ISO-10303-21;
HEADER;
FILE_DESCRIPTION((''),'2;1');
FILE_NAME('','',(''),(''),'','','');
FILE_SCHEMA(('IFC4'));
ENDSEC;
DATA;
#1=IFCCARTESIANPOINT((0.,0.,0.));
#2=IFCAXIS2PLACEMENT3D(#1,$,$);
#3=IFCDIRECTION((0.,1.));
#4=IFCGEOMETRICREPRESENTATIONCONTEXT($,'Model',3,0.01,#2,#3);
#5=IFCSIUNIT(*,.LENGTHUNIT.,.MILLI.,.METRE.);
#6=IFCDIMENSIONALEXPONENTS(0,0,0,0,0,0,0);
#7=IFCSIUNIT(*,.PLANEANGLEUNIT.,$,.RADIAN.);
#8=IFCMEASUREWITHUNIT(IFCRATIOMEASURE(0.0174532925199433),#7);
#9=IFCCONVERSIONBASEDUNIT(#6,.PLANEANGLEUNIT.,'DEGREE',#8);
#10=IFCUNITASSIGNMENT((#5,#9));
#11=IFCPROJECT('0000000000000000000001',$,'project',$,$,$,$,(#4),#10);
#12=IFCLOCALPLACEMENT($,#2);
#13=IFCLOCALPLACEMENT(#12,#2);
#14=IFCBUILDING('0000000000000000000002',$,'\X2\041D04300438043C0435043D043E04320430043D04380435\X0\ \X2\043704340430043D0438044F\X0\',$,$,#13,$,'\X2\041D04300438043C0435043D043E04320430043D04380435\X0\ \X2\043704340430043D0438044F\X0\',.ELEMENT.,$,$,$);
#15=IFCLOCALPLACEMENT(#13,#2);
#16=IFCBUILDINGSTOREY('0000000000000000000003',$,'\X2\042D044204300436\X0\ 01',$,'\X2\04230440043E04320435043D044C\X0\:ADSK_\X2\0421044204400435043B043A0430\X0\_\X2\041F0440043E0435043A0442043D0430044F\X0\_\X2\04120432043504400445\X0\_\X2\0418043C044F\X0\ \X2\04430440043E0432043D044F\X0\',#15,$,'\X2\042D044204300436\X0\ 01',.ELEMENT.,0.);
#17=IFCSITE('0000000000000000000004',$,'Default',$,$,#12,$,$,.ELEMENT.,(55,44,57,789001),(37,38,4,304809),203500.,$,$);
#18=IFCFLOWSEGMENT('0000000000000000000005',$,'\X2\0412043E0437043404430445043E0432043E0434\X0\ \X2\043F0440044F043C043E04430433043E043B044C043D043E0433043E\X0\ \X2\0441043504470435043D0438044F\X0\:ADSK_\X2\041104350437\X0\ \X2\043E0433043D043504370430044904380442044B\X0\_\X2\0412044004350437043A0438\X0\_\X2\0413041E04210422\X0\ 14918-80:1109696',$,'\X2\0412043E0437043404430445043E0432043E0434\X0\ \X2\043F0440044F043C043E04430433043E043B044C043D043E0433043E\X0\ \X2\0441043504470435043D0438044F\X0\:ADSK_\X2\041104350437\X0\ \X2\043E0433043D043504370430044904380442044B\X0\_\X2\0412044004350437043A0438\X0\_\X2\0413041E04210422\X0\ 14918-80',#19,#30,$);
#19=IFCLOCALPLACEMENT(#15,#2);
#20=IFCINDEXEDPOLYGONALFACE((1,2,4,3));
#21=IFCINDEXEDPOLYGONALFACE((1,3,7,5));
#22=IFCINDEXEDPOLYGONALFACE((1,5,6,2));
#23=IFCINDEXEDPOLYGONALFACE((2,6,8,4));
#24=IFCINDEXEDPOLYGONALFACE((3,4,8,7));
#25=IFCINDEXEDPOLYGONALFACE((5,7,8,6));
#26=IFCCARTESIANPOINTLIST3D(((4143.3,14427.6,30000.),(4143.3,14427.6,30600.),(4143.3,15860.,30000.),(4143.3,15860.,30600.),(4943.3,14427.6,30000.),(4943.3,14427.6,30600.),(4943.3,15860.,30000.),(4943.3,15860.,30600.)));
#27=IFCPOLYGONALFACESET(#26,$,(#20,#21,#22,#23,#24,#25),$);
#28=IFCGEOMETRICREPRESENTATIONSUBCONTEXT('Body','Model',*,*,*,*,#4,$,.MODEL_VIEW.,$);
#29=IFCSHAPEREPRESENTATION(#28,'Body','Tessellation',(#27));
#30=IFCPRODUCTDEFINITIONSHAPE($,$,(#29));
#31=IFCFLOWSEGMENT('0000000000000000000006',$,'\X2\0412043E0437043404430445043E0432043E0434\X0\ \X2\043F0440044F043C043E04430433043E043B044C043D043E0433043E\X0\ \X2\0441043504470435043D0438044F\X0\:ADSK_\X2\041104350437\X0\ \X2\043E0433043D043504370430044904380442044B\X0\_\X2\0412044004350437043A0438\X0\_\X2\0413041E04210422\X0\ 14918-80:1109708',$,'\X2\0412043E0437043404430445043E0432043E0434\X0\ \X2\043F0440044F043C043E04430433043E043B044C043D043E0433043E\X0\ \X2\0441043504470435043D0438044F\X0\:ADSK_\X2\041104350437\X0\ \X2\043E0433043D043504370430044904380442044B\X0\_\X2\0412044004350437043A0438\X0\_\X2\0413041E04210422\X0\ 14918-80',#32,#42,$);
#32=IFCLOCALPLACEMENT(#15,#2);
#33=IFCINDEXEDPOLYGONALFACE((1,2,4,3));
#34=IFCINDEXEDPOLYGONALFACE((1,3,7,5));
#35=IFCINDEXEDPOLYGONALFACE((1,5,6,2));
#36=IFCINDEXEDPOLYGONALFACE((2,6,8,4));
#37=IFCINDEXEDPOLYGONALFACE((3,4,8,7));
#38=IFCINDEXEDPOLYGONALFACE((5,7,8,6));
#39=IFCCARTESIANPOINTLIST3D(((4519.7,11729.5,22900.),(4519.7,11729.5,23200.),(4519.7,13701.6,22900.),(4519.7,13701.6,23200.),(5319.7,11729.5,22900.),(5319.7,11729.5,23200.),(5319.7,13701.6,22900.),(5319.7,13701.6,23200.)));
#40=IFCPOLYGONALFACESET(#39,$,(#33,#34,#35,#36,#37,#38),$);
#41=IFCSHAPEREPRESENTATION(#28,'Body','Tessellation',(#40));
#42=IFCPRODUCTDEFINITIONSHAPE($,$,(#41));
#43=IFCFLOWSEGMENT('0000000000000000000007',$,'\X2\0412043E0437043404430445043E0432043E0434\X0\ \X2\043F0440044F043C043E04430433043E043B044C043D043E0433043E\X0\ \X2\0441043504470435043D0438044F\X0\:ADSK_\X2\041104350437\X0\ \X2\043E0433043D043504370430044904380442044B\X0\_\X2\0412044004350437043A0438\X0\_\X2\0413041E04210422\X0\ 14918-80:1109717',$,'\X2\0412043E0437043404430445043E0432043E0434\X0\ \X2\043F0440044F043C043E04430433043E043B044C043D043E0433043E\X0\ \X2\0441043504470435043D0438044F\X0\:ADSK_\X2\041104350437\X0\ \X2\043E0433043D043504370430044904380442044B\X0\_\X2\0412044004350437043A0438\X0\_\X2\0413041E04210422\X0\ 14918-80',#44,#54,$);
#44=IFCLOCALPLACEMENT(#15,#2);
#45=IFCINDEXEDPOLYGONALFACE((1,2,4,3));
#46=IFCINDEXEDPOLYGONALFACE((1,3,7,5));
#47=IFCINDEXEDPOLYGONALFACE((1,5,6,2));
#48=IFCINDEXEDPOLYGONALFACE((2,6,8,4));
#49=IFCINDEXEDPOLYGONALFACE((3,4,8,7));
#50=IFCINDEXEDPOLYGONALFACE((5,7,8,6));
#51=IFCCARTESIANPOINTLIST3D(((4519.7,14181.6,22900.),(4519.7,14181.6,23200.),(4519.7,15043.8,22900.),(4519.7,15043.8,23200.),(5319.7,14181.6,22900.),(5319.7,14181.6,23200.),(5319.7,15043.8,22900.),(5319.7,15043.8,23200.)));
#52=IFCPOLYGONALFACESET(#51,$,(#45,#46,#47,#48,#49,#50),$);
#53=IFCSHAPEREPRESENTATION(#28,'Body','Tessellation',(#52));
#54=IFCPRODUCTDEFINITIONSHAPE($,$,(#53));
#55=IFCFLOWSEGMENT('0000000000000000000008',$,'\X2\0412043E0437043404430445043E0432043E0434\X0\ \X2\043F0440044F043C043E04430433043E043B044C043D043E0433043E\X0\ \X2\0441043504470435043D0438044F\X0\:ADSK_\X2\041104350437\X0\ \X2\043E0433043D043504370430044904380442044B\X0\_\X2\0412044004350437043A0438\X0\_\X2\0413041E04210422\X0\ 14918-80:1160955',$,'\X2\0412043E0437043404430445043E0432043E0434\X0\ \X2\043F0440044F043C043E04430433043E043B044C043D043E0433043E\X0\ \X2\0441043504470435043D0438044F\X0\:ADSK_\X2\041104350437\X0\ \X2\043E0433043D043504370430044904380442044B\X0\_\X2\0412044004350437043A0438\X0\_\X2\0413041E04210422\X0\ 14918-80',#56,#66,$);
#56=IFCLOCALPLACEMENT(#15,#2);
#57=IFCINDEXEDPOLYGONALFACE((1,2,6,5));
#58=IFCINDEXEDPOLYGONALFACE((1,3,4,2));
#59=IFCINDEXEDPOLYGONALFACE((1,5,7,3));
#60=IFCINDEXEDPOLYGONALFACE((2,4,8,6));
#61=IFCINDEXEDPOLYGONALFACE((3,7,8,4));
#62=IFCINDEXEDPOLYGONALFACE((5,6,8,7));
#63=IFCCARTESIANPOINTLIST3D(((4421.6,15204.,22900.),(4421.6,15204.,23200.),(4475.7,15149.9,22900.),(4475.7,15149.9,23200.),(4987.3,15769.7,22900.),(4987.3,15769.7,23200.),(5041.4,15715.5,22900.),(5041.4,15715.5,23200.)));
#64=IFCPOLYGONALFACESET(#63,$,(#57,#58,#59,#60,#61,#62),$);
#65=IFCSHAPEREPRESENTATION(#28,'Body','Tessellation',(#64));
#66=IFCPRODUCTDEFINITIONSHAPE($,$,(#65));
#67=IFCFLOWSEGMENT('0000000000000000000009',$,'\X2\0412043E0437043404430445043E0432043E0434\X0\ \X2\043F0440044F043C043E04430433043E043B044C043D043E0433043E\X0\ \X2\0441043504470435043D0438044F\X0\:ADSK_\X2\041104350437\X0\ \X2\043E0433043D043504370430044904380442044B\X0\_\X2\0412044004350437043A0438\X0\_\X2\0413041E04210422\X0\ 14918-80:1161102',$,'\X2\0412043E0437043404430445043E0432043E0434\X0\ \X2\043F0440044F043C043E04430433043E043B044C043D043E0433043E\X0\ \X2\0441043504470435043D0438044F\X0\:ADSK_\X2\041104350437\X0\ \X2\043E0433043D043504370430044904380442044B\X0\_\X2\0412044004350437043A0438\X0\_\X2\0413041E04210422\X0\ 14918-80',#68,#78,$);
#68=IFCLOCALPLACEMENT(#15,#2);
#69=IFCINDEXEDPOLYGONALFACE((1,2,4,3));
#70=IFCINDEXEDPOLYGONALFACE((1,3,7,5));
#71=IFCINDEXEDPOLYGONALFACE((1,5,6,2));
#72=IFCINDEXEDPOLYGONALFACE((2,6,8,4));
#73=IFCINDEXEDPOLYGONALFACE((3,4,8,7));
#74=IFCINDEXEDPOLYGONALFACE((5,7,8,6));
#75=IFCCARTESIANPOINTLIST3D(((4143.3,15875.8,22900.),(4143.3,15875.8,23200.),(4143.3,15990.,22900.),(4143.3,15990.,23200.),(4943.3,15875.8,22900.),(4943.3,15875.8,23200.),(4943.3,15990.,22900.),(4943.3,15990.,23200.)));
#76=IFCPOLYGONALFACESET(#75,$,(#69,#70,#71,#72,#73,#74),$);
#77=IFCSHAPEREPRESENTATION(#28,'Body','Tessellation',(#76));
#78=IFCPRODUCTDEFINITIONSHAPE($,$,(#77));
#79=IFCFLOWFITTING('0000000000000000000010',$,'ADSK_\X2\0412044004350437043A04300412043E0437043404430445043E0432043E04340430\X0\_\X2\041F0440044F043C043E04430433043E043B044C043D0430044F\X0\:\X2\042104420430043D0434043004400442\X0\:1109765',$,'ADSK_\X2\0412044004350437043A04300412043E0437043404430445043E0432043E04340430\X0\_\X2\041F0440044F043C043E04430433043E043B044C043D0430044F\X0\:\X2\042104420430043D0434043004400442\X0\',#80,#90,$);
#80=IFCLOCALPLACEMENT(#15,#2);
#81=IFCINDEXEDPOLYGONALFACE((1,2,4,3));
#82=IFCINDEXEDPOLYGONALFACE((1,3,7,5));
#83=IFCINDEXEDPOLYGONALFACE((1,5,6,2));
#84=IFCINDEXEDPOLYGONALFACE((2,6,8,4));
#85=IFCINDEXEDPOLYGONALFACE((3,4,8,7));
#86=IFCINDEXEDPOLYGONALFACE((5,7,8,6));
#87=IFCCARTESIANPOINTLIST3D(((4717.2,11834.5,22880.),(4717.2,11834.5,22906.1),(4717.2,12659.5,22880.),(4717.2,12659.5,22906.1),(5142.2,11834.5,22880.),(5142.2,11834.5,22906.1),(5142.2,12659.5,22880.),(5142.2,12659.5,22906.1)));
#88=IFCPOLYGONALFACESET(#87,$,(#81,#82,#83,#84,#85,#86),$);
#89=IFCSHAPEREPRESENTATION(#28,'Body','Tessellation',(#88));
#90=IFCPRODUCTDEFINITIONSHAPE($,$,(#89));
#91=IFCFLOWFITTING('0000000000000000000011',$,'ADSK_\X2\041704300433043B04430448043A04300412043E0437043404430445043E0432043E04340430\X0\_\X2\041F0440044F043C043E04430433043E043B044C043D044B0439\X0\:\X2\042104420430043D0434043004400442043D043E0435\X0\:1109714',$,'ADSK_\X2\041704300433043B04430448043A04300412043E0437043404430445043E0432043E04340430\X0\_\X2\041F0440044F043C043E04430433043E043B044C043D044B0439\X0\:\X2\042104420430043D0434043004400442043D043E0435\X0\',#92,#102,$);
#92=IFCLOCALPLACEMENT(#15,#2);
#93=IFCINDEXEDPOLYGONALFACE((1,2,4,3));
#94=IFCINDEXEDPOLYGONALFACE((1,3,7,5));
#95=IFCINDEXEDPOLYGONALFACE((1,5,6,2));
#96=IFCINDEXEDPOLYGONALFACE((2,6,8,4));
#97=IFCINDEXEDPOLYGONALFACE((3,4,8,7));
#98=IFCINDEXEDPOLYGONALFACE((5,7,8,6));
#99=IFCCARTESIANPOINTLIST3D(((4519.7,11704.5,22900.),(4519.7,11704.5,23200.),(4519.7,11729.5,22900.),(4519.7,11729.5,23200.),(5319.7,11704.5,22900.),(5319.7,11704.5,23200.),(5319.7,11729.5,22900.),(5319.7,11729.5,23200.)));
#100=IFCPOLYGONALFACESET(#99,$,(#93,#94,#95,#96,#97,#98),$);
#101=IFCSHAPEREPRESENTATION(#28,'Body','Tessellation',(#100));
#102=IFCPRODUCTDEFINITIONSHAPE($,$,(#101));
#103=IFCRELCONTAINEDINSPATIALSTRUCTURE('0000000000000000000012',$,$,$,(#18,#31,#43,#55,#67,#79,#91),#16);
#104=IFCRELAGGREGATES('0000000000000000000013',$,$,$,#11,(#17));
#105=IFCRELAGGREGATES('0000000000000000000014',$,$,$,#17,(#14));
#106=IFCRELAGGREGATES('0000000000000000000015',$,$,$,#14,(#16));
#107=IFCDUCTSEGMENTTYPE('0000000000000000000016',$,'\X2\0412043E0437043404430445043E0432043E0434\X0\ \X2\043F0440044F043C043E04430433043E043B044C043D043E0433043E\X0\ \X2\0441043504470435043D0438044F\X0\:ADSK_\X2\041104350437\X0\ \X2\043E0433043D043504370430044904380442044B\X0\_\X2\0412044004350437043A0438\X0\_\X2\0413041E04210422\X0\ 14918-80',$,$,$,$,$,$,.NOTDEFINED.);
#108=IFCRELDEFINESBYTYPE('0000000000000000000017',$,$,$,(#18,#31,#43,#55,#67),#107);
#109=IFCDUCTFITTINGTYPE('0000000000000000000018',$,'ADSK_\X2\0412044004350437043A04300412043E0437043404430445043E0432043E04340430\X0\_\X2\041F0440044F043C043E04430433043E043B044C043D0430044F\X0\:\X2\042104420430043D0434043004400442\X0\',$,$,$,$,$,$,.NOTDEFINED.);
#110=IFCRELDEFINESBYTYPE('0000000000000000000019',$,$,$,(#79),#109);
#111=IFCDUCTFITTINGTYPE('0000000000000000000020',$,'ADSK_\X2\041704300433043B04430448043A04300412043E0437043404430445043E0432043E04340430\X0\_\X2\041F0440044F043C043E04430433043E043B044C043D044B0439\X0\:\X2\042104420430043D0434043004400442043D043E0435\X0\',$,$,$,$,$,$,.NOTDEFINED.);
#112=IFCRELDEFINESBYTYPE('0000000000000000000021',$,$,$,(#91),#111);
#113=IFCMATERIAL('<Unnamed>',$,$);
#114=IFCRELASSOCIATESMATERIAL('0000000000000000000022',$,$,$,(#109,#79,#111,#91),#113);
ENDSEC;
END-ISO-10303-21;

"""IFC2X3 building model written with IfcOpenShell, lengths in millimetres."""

from ifc_helpers import new_model, entity, si_unit, converted_unit, direction, frame, frame_2d, origin, origin_2d_with_axis, place, context, subcontext, project, spatial, rectangle, extrude, source, transform, mapped, material, type_object, type_shapes, element, save


model = new_model("IFC2X3")

# Units and contexts
model_context = context("Model", 3, precision=0.01, world=origin(), true_north=direction((0.0, 1.0)))
body_context = subcontext(model_context, "Body", "Model", "MODEL_VIEW")
ifc_project = project(units=[si_unit("LENGTHUNIT", "METRE", prefix="MILLI"), converted_unit("PLANEANGLEUNIT", "DEGREE", entity("IfcRatioMeasure", 0.0174532925199433), si_unit("PLANEANGLEUNIT", "RADIAN"), dimensions=[0, 0, 0, 0, 0, 0, 0])], contexts=[model_context])

# Site, building, storey
site_placement = place(None, frame((0.0, 0.0, 0.0)))
site = spatial("IfcSite", under=ifc_project, at=site_placement, Name="Default", CompositionType="ELEMENT", RefLatitude=(55, 44, 57, 789001), RefLongitude=(37, 38, 4, 304809), RefElevation=203500.0)
building_placement = place(site_placement, origin())
building = spatial("IfcBuilding", under=site, at=building_placement, Name="Наименование здания", LongName="Наименование здания", CompositionType="ELEMENT")
storey_placement = place(building_placement, origin())
storey = spatial("IfcBuildingStorey", under=building, at=storey_placement, Name="Этаж 01", ObjectType="Уровень:ADSK_Стрелка_Проектная_Вверх_Имя уровня", LongName="Этаж 01", CompositionType="ELEMENT", Elevation=0.0)

# Shared definitions
ifc_material_1 = material(Name="<Unnamed>")

# Flow segments
duct_segment_type_1 = type_object("IfcDuctSegmentType", Name="Воздуховод прямоугольного сечения:ADSK_Без огнезащиты_Врезки_ГОСТ 14918-80", PredefinedType="NOTDEFINED")
flow_segment_1_placement = place(storey_placement, frame((4143.3, 14427.6, 30000.0)))
element("IfcFlowSegment", 1, at=flow_segment_1_placement, inside=storey, type_object=duct_segment_type_1, Name="Воздуховод прямоугольного сечения:ADSK_Без огнезащиты_Врезки_ГОСТ 14918-80:1109696", ObjectType="Воздуховод прямоугольного сечения:ADSK_Без огнезащиты_Врезки_ГОСТ 14918-80", context=body_context, shape_type="SweptSolid", body=[
    extrude(rectangle(XDim=1432.4, YDim=800.0, at=frame_2d((0.0, 0.0), x_axis=(1.0, 0.0))), frame((400.0, 716.2, 0.0), z_axis=(0.0, 0.0, 1.0), x_axis=(0.0, -1.0, 0.0)), (0.0, 0.0, 1.0), 600.0),
])
flow_segment_2_placement = place(storey_placement, frame((4519.7, 11729.5, 22900.0)))
element("IfcFlowSegment", 2, at=flow_segment_2_placement, inside=storey, type_object=duct_segment_type_1, Name="Воздуховод прямоугольного сечения:ADSK_Без огнезащиты_Врезки_ГОСТ 14918-80:1109708", ObjectType="Воздуховод прямоугольного сечения:ADSK_Без огнезащиты_Врезки_ГОСТ 14918-80", context=body_context, shape_type="SweptSolid", body=[
    extrude(rectangle(XDim=1972.1, YDim=800.0, at=origin_2d_with_axis()), frame((400.0, 986.0, 0.0), z_axis=(0.0, 0.0, 1.0), x_axis=(0.0, -1.0, 0.0)), (0.0, 0.0, 1.0), 300.0),
])
flow_segment_3_placement = place(storey_placement, frame((4519.7, 14181.6, 22900.0)))
element("IfcFlowSegment", 3, at=flow_segment_3_placement, inside=storey, type_object=duct_segment_type_1, Name="Воздуховод прямоугольного сечения:ADSK_Без огнезащиты_Врезки_ГОСТ 14918-80:1109717", ObjectType="Воздуховод прямоугольного сечения:ADSK_Без огнезащиты_Врезки_ГОСТ 14918-80", context=body_context, shape_type="SweptSolid", body=[
    extrude(rectangle(XDim=862.2, YDim=800.0, at=frame_2d((0.0, 0.0), x_axis=(1.0, 0.0))), frame((400.0, 431.1, 0.0), z_axis=(0.0, 0.0, 1.0), x_axis=(0.0, 1.0, 0.0)), (0.0, 0.0, 1.0), 300.0),
])
flow_segment_4_placement = place(storey_placement, frame((4421.6, 15149.9, 22900.0)))
element("IfcFlowSegment", 4, at=flow_segment_4_placement, inside=storey, type_object=duct_segment_type_1, Name="Воздуховод прямоугольного сечения:ADSK_Без огнезащиты_Врезки_ГОСТ 14918-80:1160955", ObjectType="Воздуховод прямоугольного сечения:ADSK_Без огнезащиты_Врезки_ГОСТ 14918-80", context=body_context, shape_type="SweptSolid", body=[
    extrude(rectangle(XDim=76.6, YDim=800.0, at=frame_2d((0.0, 0.0), x_axis=(1.0, 0.0))), frame((309.9, 309.9, 0.0), z_axis=(0.0, 0.0, 1.0), x_axis=(-0.707107, 0.707107, 0.0)), (0.0, 0.0, 1.0), 300.0),
])
flow_segment_5_placement = place(storey_placement, frame((4143.3, 15875.8, 22900.0)))
element("IfcFlowSegment", 5, at=flow_segment_5_placement, inside=storey, type_object=duct_segment_type_1, Name="Воздуховод прямоугольного сечения:ADSK_Без огнезащиты_Врезки_ГОСТ 14918-80:1161102", ObjectType="Воздуховод прямоугольного сечения:ADSK_Без огнезащиты_Врезки_ГОСТ 14918-80", context=body_context, shape_type="SweptSolid", body=[
    extrude(rectangle(XDim=114.2, YDim=800.0, at=frame_2d((0.0, 0.0), x_axis=(1.0, 0.0))), frame((400.0, 57.1, 0.0), z_axis=(0.0, 0.0, 1.0), x_axis=(0.0, 1.0, 0.0)), (0.0, 0.0, 1.0), 300.0),
])

# Flow fittings
duct_fitting_type_1 = type_object("IfcDuctFittingType", Name="ADSK_ВрезкаВоздуховода_Прямоугольная:Стандарт", PredefinedType="NOTDEFINED", material=ifc_material_1)
shared_shape_1 = source(origin(), body_context, "Body", "SweptSolid", [
    extrude(rectangle(XDim=825.0, YDim=26.1, at=frame_2d((0.0, 0.0), x_axis=(1.0, 0.0))), frame((7.0, 0.0, -212.5), z_axis=(0.0, 0.0, 1.0), x_axis=(0.0, -1.0, 0.0)), (0.0, 0.0, 1.0), 425.0),
])
type_shapes(duct_fitting_type_1, [shared_shape_1])
flow_fitting_1_placement = place(storey_placement, frame((4929.7, 12247.0, 22900.0), z_axis=(-1.0, 0.0, 0.0), x_axis=(0.0, 0.0, -1.0)))
element("IfcFlowFitting", 6, at=flow_fitting_1_placement, inside=storey, type_object=duct_fitting_type_1, material=ifc_material_1, Name="ADSK_ВрезкаВоздуховода_Прямоугольная:Стандарт:1109765", ObjectType="ADSK_ВрезкаВоздуховода_Прямоугольная:Стандарт", context=body_context, shape_type="MappedRepresentation", body=[
    mapped(shared_shape_1, transform((0.0, 0.0, 0.0), scale=1.0)),
])
duct_fitting_type_2 = type_object("IfcDuctFittingType", Name="ADSK_ЗаглушкаВоздуховода_Прямоугольный:Стандартное", PredefinedType="NOTDEFINED", material=ifc_material_1)
shared_shape_2 = source(origin(), body_context, "Body", "SweptSolid", [
    extrude(rectangle(XDim=25.0, YDim=800.0, at=frame_2d((0.0, 0.0), x_axis=(1.0, 0.0))), frame((12.5, 0.0, -150.0)), (0.0, 0.0, 1.0), 300.0),
])
type_shapes(duct_fitting_type_2, [shared_shape_2])
flow_fitting_2_placement = place(storey_placement, frame((4919.7, 11729.5, 23050.0), z_axis=(0.0, 0.0, 1.0), x_axis=(0.0, -1.0, 0.0)))
element("IfcFlowFitting", 7, at=flow_fitting_2_placement, inside=storey, type_object=duct_fitting_type_2, material=ifc_material_1, Name="ADSK_ЗаглушкаВоздуховода_Прямоугольный:Стандартное:1109714", ObjectType="ADSK_ЗаглушкаВоздуховода_Прямоугольный:Стандартное", context=body_context, shape_type="MappedRepresentation", body=[
    mapped(shared_shape_2, transform((0.0, 0.0, 0.0), scale=1.0)),
])

save(model, "model.ifc")
